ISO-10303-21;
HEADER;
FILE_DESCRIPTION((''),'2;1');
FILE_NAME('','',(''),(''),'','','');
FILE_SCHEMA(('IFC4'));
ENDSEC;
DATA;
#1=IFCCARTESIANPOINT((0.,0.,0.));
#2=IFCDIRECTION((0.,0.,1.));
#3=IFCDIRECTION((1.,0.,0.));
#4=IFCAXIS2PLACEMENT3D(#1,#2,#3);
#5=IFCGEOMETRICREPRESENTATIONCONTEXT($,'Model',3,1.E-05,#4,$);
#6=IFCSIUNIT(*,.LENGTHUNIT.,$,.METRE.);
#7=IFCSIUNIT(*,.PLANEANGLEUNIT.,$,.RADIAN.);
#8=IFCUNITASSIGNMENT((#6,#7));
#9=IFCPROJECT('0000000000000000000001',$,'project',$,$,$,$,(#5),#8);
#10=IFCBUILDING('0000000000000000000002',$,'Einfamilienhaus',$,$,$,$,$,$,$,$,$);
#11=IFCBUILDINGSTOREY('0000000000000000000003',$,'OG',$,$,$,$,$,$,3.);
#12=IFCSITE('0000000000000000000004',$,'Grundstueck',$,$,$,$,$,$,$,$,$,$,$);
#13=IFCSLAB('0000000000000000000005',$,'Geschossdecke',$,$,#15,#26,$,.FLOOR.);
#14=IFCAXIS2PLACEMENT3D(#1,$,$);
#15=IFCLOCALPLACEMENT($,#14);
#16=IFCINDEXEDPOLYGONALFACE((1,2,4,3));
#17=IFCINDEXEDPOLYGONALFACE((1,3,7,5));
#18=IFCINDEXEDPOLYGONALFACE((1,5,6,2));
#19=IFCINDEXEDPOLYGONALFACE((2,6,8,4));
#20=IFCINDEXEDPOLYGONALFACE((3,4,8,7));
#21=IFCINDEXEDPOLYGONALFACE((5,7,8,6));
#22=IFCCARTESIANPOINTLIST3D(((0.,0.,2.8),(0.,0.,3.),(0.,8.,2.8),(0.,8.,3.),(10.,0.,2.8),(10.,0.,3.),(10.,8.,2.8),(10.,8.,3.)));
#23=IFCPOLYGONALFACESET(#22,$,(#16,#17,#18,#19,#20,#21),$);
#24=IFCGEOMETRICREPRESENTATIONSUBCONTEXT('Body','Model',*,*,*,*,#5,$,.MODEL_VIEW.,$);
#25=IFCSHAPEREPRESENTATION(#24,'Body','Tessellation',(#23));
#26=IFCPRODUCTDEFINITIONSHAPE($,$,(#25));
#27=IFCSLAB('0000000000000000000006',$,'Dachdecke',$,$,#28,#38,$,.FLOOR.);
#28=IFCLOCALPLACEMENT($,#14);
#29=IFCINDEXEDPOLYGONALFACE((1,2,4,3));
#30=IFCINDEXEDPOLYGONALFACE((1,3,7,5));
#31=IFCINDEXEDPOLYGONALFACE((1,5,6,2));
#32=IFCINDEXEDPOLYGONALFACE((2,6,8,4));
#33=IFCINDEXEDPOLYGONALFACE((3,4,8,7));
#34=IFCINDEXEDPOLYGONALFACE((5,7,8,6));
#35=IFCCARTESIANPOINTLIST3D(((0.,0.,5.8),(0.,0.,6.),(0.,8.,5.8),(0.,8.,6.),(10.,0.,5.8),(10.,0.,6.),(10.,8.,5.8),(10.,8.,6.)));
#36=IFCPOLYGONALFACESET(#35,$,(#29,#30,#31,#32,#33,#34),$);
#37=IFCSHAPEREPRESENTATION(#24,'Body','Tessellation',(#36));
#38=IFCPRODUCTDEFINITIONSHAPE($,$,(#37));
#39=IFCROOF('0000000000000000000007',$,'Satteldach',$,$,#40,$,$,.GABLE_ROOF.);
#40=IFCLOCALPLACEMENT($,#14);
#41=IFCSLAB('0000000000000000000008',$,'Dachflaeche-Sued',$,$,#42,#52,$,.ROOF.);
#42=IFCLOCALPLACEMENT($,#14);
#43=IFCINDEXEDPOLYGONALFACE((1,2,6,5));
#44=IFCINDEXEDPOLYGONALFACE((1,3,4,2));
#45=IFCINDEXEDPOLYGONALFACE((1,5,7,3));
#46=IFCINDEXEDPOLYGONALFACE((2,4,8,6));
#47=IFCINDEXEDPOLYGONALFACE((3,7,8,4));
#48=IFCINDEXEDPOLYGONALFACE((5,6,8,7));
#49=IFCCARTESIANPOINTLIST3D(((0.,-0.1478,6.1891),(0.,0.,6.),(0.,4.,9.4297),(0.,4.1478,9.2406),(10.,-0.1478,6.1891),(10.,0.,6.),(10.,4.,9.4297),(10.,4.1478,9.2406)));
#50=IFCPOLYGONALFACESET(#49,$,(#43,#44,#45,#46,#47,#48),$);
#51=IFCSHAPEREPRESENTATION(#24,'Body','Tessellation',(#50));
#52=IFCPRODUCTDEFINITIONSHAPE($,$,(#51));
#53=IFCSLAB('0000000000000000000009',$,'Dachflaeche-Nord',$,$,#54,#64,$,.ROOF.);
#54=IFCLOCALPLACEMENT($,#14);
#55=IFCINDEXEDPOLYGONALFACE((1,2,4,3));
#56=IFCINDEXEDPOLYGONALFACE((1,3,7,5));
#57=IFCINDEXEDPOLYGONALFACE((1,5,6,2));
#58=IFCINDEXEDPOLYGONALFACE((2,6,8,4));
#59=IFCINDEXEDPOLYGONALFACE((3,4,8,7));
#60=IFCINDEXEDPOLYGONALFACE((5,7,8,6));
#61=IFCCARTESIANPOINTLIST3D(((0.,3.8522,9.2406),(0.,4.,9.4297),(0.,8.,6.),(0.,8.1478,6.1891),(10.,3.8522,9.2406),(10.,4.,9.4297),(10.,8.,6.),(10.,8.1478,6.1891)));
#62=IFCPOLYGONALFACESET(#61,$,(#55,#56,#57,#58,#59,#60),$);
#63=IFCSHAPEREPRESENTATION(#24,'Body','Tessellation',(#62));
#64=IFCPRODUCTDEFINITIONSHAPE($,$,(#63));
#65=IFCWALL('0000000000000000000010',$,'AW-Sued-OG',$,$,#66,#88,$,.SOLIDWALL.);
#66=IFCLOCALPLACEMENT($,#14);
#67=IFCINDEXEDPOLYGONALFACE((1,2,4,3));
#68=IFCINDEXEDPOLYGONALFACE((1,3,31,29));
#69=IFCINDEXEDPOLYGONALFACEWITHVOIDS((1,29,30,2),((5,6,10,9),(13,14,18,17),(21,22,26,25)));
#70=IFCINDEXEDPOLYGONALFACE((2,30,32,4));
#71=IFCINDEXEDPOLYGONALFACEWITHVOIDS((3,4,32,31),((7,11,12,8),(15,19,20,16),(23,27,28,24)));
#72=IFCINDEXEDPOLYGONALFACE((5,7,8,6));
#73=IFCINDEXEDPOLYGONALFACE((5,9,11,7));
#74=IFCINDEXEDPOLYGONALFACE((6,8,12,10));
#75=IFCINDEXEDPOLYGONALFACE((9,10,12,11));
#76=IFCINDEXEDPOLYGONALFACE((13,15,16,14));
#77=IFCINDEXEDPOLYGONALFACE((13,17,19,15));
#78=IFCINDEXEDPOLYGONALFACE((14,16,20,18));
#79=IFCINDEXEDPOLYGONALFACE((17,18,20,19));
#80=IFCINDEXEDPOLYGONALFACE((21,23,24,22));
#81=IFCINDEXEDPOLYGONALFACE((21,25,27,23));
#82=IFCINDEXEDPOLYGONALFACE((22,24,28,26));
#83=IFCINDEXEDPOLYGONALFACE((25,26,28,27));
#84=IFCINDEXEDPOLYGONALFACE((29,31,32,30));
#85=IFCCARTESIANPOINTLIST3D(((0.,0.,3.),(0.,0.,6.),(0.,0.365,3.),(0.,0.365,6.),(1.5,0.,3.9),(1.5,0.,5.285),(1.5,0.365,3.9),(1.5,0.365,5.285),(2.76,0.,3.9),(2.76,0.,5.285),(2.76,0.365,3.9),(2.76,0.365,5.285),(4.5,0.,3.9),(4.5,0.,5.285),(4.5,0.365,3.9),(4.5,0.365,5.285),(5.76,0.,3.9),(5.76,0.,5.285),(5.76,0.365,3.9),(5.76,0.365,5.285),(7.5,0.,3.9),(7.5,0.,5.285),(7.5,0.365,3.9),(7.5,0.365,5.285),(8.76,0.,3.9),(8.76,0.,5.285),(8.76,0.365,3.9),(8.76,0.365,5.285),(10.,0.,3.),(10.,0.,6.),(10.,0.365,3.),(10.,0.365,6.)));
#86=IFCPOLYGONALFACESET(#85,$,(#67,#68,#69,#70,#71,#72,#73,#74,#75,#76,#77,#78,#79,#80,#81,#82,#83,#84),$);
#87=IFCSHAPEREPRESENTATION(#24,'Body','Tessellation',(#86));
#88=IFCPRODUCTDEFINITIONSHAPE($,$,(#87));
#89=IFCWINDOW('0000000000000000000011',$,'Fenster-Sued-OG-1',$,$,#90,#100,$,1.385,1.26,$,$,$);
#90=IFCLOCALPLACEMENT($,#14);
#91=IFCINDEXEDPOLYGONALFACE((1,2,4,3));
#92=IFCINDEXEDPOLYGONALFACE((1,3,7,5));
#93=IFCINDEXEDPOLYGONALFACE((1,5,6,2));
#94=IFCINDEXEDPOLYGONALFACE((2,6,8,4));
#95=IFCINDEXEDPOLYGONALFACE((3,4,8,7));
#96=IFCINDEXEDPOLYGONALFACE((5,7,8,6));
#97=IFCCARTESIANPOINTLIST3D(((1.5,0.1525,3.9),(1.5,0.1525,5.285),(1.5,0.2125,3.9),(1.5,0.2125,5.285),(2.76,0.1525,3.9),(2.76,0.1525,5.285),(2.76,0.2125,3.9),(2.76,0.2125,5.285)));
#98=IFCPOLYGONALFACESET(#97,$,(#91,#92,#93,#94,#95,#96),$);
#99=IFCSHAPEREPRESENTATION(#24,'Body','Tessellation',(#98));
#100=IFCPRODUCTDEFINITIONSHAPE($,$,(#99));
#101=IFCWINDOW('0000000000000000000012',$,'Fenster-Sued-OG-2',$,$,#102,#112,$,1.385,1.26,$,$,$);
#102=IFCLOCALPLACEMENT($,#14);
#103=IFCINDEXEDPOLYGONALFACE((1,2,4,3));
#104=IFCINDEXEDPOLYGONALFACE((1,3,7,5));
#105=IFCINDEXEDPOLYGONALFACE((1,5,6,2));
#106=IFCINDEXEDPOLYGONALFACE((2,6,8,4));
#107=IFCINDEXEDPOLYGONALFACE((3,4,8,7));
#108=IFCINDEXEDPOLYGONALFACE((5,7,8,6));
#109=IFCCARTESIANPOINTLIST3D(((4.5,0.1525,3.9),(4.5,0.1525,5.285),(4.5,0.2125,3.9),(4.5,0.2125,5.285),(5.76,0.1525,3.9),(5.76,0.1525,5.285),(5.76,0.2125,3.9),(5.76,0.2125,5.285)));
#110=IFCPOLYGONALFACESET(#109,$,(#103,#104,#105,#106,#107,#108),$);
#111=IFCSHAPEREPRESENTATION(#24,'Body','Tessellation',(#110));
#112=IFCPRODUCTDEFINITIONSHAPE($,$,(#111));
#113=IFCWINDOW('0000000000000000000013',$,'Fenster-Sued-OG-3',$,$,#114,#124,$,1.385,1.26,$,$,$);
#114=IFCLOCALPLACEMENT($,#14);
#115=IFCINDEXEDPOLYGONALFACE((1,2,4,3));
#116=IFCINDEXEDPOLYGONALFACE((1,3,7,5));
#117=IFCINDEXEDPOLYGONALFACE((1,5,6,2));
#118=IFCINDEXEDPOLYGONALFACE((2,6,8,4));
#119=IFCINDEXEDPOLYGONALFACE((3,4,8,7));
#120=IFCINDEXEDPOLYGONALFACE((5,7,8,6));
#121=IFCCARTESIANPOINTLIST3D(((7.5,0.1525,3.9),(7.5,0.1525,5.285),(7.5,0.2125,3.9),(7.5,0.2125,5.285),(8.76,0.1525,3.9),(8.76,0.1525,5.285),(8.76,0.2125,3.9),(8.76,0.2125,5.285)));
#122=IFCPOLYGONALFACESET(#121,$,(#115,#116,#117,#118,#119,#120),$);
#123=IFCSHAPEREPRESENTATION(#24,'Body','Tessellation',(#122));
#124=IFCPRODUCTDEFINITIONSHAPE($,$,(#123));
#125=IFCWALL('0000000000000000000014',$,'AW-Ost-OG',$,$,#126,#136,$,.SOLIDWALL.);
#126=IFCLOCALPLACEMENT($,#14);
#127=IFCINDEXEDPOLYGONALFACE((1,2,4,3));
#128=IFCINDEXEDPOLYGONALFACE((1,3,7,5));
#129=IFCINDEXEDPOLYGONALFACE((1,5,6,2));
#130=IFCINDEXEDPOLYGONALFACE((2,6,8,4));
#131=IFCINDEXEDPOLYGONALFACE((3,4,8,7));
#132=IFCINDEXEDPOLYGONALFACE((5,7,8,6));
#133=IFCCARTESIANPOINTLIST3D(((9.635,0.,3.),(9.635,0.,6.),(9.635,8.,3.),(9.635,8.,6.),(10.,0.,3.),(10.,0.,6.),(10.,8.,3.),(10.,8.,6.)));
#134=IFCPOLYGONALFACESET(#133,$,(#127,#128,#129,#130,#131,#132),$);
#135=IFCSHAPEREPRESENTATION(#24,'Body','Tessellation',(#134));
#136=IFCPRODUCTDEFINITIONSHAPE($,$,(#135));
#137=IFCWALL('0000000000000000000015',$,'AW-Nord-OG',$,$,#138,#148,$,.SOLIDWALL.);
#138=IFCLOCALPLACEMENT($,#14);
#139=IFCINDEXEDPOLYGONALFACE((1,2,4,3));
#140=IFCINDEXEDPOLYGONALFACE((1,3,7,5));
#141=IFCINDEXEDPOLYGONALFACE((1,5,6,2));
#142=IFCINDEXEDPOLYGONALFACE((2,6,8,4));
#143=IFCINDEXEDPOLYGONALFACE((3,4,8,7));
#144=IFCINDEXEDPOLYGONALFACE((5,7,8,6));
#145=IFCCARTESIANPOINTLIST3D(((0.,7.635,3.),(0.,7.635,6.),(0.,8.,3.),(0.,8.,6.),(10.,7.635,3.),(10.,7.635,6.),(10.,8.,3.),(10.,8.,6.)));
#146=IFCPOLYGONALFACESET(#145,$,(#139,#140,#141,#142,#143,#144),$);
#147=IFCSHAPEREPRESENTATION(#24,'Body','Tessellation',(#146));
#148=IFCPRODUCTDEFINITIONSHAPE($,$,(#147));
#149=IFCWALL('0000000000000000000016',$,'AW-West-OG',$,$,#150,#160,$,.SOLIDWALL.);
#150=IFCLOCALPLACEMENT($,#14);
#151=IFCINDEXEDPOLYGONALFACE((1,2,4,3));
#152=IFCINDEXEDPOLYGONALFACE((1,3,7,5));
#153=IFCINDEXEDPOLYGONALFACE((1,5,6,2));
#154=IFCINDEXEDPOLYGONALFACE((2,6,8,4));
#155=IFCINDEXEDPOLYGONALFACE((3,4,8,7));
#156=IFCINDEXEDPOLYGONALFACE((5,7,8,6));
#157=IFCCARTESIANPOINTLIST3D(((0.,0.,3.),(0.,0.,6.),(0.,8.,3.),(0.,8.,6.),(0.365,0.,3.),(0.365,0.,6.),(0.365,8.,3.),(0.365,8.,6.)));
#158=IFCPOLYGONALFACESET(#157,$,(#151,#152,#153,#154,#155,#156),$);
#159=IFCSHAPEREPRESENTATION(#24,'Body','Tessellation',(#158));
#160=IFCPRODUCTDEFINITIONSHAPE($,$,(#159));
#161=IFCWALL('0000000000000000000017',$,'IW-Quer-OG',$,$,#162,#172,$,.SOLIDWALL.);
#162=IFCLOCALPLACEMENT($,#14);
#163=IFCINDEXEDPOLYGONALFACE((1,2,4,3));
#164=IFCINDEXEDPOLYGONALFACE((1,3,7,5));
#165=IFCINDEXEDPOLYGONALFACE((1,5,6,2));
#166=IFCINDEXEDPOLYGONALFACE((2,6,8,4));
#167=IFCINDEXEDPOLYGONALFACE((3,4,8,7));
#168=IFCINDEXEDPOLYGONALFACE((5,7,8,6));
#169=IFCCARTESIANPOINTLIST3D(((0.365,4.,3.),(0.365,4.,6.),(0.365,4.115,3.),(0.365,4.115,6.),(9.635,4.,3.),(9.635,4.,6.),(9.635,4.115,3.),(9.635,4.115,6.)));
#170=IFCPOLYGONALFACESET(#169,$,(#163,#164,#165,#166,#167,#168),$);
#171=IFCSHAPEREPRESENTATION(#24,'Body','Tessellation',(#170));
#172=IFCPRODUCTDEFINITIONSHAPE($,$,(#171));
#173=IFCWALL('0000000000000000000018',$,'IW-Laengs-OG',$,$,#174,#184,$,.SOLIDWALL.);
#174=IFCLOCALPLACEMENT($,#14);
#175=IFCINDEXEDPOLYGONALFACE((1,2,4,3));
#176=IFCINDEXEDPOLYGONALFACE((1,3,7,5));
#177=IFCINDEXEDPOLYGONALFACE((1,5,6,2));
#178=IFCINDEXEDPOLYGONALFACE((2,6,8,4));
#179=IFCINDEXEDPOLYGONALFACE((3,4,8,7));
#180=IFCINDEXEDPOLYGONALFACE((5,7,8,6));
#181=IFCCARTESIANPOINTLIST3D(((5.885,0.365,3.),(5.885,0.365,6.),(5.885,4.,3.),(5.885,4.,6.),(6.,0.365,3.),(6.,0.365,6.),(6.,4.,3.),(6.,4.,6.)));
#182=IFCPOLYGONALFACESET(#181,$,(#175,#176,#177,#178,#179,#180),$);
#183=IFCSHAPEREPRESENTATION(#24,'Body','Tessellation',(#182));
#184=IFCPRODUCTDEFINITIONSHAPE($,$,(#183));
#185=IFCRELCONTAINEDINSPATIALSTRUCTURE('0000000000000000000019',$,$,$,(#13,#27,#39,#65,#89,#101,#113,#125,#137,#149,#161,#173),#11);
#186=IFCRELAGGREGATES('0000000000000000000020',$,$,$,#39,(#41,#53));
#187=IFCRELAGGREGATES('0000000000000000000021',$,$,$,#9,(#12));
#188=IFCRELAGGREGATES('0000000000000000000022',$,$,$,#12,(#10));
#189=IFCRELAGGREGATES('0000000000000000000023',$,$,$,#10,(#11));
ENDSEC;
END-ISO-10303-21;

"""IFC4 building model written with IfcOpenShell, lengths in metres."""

from ifc_helpers import new_model, si_unit, frame, origin_with_axes, place, context, subcontext, project, spatial, indexed_curve, outline, extrude, element, fill, aggregate, save


model = new_model("IFC4")

# Units and contexts
model_context = context("Model", 3, precision=1e-05, world=origin_with_axes())
body_context = subcontext(model_context, "Body", "Model", "MODEL_VIEW")
ifc_project = project(units=[si_unit("LENGTHUNIT", "METRE"), si_unit("PLANEANGLEUNIT", "RADIAN")], contexts=[model_context])

# Site, building, storey
site = spatial("IfcSite", under=ifc_project, Name="Grundstueck")
building = spatial("IfcBuilding", under=site, Name="Einfamilienhaus")
storey = spatial("IfcBuildingStorey", under=building, Name="OG", Elevation=3.0)

# Slabs
for number, where, z_axis, x_axis, name in (
    (1, (0.0, 0.0, 2.8), (0.0, 0.0, 1.0), (1.0, 0.0, 0.0), "Geschossdecke"),
    (2, (0.0, 0.0, 5.8), (0.0, 0.0, 1.0), (1.0, 0.0, 0.0), "Dachdecke"),
):
    element("IfcSlab", number, at=place(None, frame(where, z_axis=z_axis, x_axis=x_axis)), inside=storey, Name=name, PredefinedType="FLOOR", context=body_context, shape_type="SweptSolid", body=[
        extrude(outline(indexed_curve([(0.0, 0.0), (10.0, 0.0), (10.0, 8.0), (0.0, 8.0)])), None, (0.0, 0.0, 1.0), 0.2),
    ])

# Roof, slabs
roof_placement = place(None, frame((0.0, 0.0, 6.0), z_axis=(0.0, 0.0, 1.0), x_axis=(1.0, 0.0, 0.0)))
roof = element("IfcRoof", 3, at=roof_placement, inside=storey, Name="Satteldach", PredefinedType="GABLE_ROOF")
slab_1_placement = place(roof_placement, frame((10.0, 0.0, 0.0), z_axis=(0.0, -0.615661, 0.788011), x_axis=(0.0, 0.788011, 0.615661)))
slab_1 = element("IfcSlab", 4, at=slab_1_placement, Name="Dachflaeche-Sued", PredefinedType="ROOF", context=body_context, shape_type="SweptSolid", body=[
    extrude(outline(indexed_curve([(0.0, 0.0), (5.2636, 0.0), (5.2636, 10.0), (0.0, 10.0)])), None, (0.0, 0.0, 1.0), 0.24),
])
slab_2_placement = place(roof_placement, frame((0.0, 8.0, 0.0), z_axis=(0.0, 0.615661, 0.788011), x_axis=(0.0, -0.788011, 0.615661)))
slab_2 = element("IfcSlab", 5, at=slab_2_placement, Name="Dachflaeche-Nord", PredefinedType="ROOF", context=body_context, shape_type="SweptSolid", body=[
    extrude(outline(indexed_curve([(0.0, 0.0), (5.2636, 0.0), (5.2636, 10.0), (0.0, 10.0)])), None, (0.0, 0.0, 1.0), 0.24),
])
aggregate(roof, [slab_1, slab_2])

# Wall, openings, windows
wall_1_placement = place(None, frame((0.0, 0.0, 3.0), z_axis=(0.0, 0.0, 1.0), x_axis=(1.0, 0.0, 0.0)))
wall_1 = element("IfcWall", 6, at=wall_1_placement, inside=storey, Name="AW-Sued-OG", PredefinedType="SOLIDWALL", context=body_context, shape_type="SweptSolid", body=[
    extrude(outline(indexed_curve([(0.0, 0.0), (0.0, 0.365), (10.0, 0.365), (10.0, 0.0), (0.0, 0.0)], self_intersect=False)), origin_with_axes(), (0.0, 0.0, 1.0), 3.0),
])
opening_1_placement = place(wall_1_placement, frame((1.5, 0.0, 0.9), z_axis=(0.0, 0.0, 1.0), x_axis=(1.0, 0.0, 0.0)))
opening_1 = element("IfcOpeningElement", 7, at=opening_1_placement, cuts=wall_1, PredefinedType="OPENING", context=body_context, shape_type="SweptSolid", body=[
    extrude(outline(indexed_curve([(0.0, 0.0), (0.0, 0.465), (1.26, 0.465), (1.26, 0.0), (0.0, 0.0)], self_intersect=False)), frame((0.0, -0.05, 0.0), z_axis=(0.0, 0.0, 1.0), x_axis=(1.0, 0.0, 0.0)), (0.0, 0.0, 1.0), 1.385),
])
opening_2_placement = place(wall_1_placement, frame((4.5, 0.0, 0.9), z_axis=(0.0, 0.0, 1.0), x_axis=(1.0, 0.0, 0.0)))
opening_2 = element("IfcOpeningElement", 8, at=opening_2_placement, cuts=wall_1, PredefinedType="OPENING", context=body_context, shape_type="SweptSolid", body=[
    extrude(outline(indexed_curve([(0.0, 0.0), (0.0, 0.465), (1.26, 0.465), (1.26, 0.0), (0.0, 0.0)], self_intersect=False)), frame((0.0, -0.05, 0.0), z_axis=(0.0, 0.0, 1.0), x_axis=(1.0, 0.0, 0.0)), (0.0, 0.0, 1.0), 1.385),
])
opening_3_placement = place(wall_1_placement, frame((7.5, 0.0, 0.9), z_axis=(0.0, 0.0, 1.0), x_axis=(1.0, 0.0, 0.0)))
opening_3 = element("IfcOpeningElement", 9, at=opening_3_placement, cuts=wall_1, PredefinedType="OPENING", context=body_context, shape_type="SweptSolid", body=[
    extrude(outline(indexed_curve([(0.0, 0.0), (0.0, 0.465), (1.26, 0.465), (1.26, 0.0), (0.0, 0.0)], self_intersect=False)), frame((0.0, -0.05, 0.0), z_axis=(0.0, 0.0, 1.0), x_axis=(1.0, 0.0, 0.0)), (0.0, 0.0, 1.0), 1.385),
])
window_1_placement = place(opening_1_placement, origin_with_axes())
window_1 = element("IfcWindow", 10, at=window_1_placement, inside=storey, Name="Fenster-Sued-OG-1", OverallHeight=1.385, OverallWidth=1.26, context=body_context, shape_type="SweptSolid", body=[
    extrude(outline(indexed_curve([(0.0, 0.0), (0.0, 0.06), (1.26, 0.06), (1.26, 0.0), (0.0, 0.0)], self_intersect=False)), frame((0.0, 0.1525, 0.0), z_axis=(0.0, 0.0, 1.0), x_axis=(1.0, 0.0, 0.0)), (0.0, 0.0, 1.0), 1.385),
])
fill(opening_1, window_1)
window_2_placement = place(opening_2_placement, origin_with_axes())
window_2 = element("IfcWindow", 11, at=window_2_placement, inside=storey, Name="Fenster-Sued-OG-2", OverallHeight=1.385, OverallWidth=1.26, context=body_context, shape_type="SweptSolid", body=[
    extrude(outline(indexed_curve([(0.0, 0.0), (0.0, 0.06), (1.26, 0.06), (1.26, 0.0), (0.0, 0.0)], self_intersect=False)), frame((0.0, 0.1525, 0.0), z_axis=(0.0, 0.0, 1.0), x_axis=(1.0, 0.0, 0.0)), (0.0, 0.0, 1.0), 1.385),
])
fill(opening_2, window_2)
window_3_placement = place(opening_3_placement, origin_with_axes())
window_3 = element("IfcWindow", 12, at=window_3_placement, inside=storey, Name="Fenster-Sued-OG-3", OverallHeight=1.385, OverallWidth=1.26, context=body_context, shape_type="SweptSolid", body=[
    extrude(outline(indexed_curve([(0.0, 0.0), (0.0, 0.06), (1.26, 0.06), (1.26, 0.0), (0.0, 0.0)], self_intersect=False)), frame((0.0, 0.1525, 0.0), z_axis=(0.0, 0.0, 1.0), x_axis=(1.0, 0.0, 0.0)), (0.0, 0.0, 1.0), 1.385),
])
fill(opening_3, window_3)

# Walls
wall_2_placement = place(None, frame((10.0, 0.0, 3.0), z_axis=(0.0, 0.0, 1.0), x_axis=(0.0, 1.0, 0.0)))
element("IfcWall", 13, at=wall_2_placement, inside=storey, Name="AW-Ost-OG", PredefinedType="SOLIDWALL", context=body_context, shape_type="SweptSolid", body=[
    extrude(outline(indexed_curve([(0.0, 0.0), (0.0, 0.365), (8.0, 0.365), (8.0, 0.0), (0.0, 0.0)], self_intersect=False)), origin_with_axes(), (0.0, 0.0, 1.0), 3.0),
])
wall_3_placement = place(None, frame((10.0, 8.0, 3.0), z_axis=(0.0, 0.0, 1.0), x_axis=(-1.0, 0.0, 0.0)))
element("IfcWall", 14, at=wall_3_placement, inside=storey, Name="AW-Nord-OG", PredefinedType="SOLIDWALL", context=body_context, shape_type="SweptSolid", body=[
    extrude(outline(indexed_curve([(0.0, 0.0), (0.0, 0.365), (10.0, 0.365), (10.0, 0.0), (0.0, 0.0)], self_intersect=False)), origin_with_axes(), (0.0, 0.0, 1.0), 3.0),
])
wall_4_placement = place(None, frame((0.0, 8.0, 3.0), z_axis=(0.0, 0.0, 1.0), x_axis=(0.0, -1.0, 0.0)))
element("IfcWall", 15, at=wall_4_placement, inside=storey, Name="AW-West-OG", PredefinedType="SOLIDWALL", context=body_context, shape_type="SweptSolid", body=[
    extrude(outline(indexed_curve([(0.0, 0.0), (0.0, 0.365), (8.0, 0.365), (8.0, 0.0), (0.0, 0.0)], self_intersect=False)), origin_with_axes(), (0.0, 0.0, 1.0), 3.0),
])
wall_5_placement = place(None, frame((0.365, 4.0, 3.0), z_axis=(0.0, 0.0, 1.0), x_axis=(1.0, 0.0, 0.0)))
element("IfcWall", 16, at=wall_5_placement, inside=storey, Name="IW-Quer-OG", PredefinedType="SOLIDWALL", context=body_context, shape_type="SweptSolid", body=[
    extrude(outline(indexed_curve([(0.0, 0.0), (0.0, 0.115), (9.27, 0.115), (9.27, 0.0), (0.0, 0.0)], self_intersect=False)), origin_with_axes(), (0.0, 0.0, 1.0), 3.0),
])
wall_6_placement = place(None, frame((6.0, 0.365, 3.0), z_axis=(0.0, 0.0, 1.0), x_axis=(0.0, 1.0, 0.0)))
element("IfcWall", 17, at=wall_6_placement, inside=storey, Name="IW-Laengs-OG", PredefinedType="SOLIDWALL", context=body_context, shape_type="SweptSolid", body=[
    extrude(outline(indexed_curve([(0.0, 0.0), (0.0, 0.115), (3.635, 0.115), (3.635, 0.0), (0.0, 0.0)], self_intersect=False)), origin_with_axes(), (0.0, 0.0, 1.0), 3.0),
])

save(model, "model.ifc")
